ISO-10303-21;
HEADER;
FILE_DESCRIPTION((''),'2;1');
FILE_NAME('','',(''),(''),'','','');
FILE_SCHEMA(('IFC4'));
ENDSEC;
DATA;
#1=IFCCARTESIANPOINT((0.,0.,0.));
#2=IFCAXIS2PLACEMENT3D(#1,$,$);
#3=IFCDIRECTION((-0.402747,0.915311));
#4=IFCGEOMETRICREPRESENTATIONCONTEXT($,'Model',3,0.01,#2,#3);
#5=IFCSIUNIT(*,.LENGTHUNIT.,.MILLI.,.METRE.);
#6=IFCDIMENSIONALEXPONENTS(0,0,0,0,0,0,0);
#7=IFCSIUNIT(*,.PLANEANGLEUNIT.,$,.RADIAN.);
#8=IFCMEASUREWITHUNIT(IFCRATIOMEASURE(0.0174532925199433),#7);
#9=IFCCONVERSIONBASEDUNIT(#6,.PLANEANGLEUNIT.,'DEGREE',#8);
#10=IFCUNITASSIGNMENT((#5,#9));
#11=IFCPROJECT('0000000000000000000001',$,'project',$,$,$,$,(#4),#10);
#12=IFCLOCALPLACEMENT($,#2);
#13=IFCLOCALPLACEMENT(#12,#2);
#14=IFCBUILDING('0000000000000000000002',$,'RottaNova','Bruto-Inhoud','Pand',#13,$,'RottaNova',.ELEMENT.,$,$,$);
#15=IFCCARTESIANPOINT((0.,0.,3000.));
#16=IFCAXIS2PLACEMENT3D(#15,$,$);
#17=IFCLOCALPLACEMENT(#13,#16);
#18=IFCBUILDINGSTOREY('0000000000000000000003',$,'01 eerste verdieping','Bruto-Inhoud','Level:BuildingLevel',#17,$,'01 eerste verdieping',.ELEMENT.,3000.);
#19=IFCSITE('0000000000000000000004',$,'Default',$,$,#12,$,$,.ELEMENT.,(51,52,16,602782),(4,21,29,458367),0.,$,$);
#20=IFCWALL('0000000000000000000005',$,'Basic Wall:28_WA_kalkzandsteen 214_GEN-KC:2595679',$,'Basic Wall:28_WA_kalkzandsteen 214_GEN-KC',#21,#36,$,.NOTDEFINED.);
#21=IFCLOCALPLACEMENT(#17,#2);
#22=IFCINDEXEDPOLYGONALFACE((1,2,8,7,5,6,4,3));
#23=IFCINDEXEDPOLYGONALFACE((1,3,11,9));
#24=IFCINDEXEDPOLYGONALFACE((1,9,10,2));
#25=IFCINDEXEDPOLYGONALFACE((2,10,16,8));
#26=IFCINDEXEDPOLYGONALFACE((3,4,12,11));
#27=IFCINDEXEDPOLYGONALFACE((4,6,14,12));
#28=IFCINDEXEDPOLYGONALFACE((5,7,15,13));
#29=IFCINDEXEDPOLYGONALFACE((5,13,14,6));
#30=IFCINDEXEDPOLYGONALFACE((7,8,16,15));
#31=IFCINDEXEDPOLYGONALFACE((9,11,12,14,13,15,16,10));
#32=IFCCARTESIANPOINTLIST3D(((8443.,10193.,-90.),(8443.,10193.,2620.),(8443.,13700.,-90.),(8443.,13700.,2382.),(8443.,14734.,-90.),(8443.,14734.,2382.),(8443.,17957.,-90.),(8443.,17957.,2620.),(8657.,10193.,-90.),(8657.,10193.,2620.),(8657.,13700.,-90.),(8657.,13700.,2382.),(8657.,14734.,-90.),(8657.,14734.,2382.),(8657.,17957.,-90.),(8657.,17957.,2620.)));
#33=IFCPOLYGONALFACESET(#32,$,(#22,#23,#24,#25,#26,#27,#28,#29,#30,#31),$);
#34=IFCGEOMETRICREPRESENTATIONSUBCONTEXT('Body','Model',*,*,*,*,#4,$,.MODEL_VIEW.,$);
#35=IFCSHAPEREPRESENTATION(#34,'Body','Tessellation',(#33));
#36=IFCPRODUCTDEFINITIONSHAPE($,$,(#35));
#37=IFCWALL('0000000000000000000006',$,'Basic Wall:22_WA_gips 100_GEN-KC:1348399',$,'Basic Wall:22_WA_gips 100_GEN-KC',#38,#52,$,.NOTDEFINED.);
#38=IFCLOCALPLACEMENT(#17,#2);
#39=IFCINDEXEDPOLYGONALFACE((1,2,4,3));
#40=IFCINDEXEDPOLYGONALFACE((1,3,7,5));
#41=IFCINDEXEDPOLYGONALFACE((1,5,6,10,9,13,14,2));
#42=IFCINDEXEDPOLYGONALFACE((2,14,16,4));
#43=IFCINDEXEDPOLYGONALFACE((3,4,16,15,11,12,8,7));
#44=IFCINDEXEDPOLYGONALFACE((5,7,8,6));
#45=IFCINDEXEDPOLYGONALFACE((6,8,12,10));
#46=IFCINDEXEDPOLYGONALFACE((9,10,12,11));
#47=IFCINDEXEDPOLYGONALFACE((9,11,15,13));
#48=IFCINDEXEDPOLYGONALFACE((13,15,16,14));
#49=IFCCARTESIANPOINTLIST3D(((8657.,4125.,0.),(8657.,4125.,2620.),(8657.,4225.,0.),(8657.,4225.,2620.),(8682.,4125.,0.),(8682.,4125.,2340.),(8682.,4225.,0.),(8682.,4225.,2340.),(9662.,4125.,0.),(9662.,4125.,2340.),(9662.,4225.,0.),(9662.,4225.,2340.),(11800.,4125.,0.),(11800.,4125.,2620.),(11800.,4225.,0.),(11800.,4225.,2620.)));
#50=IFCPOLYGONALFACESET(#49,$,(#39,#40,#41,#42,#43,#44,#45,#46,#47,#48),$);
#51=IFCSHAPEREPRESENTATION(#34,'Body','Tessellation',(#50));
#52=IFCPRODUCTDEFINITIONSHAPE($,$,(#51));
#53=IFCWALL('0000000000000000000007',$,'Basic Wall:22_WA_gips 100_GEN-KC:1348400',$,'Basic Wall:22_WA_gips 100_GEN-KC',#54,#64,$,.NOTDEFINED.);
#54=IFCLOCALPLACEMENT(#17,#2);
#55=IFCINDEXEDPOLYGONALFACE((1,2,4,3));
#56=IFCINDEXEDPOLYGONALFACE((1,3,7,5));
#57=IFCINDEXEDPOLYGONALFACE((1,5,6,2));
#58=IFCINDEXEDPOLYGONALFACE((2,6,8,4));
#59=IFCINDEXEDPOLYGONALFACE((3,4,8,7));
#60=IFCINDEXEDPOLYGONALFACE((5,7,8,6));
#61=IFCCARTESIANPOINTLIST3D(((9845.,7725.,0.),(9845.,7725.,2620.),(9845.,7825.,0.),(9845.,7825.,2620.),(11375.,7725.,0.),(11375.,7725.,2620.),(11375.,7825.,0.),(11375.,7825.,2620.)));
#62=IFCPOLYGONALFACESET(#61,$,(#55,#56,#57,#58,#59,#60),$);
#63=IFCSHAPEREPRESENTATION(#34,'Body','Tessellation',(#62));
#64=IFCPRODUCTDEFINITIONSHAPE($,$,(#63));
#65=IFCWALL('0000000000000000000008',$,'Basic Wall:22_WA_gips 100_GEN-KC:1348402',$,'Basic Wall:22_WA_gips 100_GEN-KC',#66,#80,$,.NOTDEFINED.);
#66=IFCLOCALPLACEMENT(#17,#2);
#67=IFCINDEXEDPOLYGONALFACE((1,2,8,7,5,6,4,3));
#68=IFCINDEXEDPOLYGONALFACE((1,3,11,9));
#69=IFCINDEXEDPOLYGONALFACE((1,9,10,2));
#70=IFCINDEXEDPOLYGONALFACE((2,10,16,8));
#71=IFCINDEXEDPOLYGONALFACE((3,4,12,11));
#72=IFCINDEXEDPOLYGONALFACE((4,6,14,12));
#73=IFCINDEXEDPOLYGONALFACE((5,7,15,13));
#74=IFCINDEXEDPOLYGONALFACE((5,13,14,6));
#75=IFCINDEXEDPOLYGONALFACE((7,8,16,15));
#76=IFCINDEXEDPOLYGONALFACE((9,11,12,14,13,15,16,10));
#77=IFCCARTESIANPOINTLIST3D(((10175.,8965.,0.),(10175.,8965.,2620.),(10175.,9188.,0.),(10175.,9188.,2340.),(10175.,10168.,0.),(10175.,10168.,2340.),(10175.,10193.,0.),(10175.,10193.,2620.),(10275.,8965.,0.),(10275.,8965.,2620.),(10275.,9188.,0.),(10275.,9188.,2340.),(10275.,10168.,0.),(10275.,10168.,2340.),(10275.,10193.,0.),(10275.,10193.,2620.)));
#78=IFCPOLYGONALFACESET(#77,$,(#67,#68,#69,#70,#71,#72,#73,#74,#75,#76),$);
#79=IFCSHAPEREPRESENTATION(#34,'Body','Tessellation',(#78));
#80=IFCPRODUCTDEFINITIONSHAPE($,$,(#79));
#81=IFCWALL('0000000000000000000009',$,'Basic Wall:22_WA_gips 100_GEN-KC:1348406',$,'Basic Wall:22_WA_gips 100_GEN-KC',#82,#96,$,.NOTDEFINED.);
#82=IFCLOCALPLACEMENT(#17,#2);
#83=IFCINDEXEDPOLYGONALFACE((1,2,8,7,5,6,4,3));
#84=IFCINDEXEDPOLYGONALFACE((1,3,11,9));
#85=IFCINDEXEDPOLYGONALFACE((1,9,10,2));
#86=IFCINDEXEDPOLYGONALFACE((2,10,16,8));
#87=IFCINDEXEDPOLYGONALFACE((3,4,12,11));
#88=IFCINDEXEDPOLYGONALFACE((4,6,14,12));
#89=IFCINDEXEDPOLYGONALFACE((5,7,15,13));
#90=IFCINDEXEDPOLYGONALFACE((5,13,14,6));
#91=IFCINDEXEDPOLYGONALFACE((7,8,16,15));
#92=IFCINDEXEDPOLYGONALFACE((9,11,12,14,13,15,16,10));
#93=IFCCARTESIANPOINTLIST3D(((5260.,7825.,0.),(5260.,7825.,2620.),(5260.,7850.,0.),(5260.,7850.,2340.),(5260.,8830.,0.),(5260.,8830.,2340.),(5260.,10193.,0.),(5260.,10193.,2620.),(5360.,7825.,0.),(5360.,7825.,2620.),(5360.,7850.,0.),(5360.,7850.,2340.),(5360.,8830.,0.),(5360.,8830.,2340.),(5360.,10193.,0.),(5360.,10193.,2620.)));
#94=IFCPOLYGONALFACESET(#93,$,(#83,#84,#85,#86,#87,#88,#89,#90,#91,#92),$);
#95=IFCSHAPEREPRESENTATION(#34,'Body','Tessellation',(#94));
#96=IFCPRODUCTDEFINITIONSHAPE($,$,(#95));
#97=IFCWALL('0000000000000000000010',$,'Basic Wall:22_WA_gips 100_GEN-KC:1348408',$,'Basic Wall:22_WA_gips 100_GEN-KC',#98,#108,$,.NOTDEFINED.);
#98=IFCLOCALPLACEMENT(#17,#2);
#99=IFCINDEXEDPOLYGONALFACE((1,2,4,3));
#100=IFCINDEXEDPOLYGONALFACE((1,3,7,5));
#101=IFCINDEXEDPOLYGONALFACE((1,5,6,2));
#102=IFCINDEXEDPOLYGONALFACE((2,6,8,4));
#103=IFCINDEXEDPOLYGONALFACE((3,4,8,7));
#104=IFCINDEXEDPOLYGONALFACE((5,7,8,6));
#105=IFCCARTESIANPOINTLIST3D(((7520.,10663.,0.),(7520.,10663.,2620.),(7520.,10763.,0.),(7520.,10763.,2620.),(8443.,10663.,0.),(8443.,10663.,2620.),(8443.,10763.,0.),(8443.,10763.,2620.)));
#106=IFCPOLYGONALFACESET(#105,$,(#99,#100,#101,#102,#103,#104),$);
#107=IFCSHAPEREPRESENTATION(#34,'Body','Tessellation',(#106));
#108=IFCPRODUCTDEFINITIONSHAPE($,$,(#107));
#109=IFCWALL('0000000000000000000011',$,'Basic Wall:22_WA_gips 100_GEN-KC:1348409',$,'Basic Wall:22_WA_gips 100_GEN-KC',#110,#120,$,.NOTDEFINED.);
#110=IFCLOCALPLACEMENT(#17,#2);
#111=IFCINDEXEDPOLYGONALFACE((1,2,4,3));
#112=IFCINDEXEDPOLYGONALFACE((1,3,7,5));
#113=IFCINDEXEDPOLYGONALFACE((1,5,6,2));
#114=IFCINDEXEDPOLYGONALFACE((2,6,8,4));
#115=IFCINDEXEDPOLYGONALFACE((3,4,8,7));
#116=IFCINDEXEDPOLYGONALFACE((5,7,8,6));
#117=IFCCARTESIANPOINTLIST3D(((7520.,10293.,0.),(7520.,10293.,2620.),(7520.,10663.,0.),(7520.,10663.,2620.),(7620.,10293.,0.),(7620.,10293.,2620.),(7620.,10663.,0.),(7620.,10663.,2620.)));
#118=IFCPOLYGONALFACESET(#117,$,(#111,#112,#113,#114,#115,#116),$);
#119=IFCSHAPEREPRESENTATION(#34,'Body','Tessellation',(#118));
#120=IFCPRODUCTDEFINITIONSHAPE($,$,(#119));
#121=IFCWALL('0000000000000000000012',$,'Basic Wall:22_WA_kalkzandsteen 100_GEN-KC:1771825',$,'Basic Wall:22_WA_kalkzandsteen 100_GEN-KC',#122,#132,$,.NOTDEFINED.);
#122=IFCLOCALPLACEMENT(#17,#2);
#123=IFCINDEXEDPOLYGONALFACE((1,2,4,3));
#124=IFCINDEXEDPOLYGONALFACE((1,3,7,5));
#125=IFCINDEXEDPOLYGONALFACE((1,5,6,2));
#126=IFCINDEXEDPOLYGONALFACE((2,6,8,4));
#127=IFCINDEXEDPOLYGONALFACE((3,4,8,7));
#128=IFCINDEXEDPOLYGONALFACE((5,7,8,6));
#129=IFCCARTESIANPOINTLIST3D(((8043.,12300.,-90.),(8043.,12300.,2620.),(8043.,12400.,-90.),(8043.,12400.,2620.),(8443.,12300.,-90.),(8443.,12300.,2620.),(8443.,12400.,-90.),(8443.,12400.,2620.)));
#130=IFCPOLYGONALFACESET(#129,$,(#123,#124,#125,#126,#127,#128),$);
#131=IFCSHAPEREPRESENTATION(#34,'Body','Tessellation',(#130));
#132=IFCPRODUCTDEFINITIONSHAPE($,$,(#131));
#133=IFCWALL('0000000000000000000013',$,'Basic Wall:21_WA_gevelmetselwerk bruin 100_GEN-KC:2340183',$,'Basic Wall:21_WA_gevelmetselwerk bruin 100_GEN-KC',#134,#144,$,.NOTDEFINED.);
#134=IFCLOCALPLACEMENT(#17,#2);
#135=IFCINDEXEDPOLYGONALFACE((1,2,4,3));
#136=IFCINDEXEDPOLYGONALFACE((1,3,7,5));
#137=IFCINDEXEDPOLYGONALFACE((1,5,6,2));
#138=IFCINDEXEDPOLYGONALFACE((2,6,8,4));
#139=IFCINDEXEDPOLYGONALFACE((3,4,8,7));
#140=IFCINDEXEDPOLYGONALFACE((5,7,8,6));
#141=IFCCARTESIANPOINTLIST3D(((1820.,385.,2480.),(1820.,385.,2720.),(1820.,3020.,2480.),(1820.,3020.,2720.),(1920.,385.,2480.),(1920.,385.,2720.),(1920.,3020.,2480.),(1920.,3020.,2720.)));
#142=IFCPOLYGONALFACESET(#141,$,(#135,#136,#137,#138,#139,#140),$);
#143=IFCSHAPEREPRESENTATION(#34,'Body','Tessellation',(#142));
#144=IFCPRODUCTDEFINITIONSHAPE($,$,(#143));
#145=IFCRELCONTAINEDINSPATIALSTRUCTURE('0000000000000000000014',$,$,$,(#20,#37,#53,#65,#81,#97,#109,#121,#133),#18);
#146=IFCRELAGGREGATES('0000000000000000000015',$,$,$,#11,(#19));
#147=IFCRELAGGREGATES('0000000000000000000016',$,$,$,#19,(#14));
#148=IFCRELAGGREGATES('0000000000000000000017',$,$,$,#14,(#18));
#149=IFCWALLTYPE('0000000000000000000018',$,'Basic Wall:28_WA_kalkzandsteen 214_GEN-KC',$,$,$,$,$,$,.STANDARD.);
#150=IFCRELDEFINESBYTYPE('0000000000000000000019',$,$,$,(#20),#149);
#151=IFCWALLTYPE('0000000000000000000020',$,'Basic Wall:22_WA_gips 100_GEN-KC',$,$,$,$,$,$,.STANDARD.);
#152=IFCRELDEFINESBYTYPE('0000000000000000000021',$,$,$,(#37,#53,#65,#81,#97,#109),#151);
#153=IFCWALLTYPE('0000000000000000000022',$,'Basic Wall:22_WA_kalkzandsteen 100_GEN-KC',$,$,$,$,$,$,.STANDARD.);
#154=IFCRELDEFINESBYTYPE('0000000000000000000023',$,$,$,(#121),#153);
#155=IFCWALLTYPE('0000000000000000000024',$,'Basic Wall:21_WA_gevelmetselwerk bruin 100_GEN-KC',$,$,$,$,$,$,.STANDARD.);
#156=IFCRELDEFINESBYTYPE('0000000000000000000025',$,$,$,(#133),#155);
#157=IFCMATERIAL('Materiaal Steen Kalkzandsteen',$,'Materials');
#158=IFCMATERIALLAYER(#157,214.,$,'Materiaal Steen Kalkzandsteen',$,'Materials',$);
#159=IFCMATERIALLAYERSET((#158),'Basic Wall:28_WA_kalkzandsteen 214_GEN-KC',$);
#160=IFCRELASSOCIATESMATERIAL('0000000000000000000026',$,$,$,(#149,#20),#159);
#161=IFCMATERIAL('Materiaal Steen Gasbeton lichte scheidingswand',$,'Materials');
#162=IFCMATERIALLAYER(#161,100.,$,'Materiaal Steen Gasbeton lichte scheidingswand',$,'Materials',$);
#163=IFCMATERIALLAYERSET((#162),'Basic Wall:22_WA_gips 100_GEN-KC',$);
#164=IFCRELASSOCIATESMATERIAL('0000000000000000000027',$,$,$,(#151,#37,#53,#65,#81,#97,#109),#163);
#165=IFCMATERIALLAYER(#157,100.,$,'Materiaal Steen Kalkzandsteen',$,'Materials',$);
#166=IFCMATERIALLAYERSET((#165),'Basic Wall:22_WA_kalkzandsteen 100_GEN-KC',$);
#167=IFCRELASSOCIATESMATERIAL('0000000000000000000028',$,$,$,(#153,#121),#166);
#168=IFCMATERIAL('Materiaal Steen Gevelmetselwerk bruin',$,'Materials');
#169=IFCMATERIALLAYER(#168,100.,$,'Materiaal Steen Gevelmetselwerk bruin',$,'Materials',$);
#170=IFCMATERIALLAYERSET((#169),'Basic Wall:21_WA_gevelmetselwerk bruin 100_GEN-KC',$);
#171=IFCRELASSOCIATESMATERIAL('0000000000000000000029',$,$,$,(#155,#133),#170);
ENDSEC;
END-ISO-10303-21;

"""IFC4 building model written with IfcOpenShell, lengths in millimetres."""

from ifc_helpers import new_model, entity, si_unit, converted_unit, direction, frame, frame_2d, origin, place, context, subcontext, project, spatial, rectangle, extrude, material, layer, layer_set, type_object, element, save


model = new_model("IFC4")

# Units and contexts
model_context = context("Model", 3, precision=0.01, world=origin(), true_north=direction((-0.402747, 0.915311)))
body_context = subcontext(model_context, "Body", "Model", "MODEL_VIEW")
ifc_project = project(units=[si_unit("LENGTHUNIT", "METRE", prefix="MILLI"), converted_unit("PLANEANGLEUNIT", "DEGREE", entity("IfcRatioMeasure", 0.0174532925199433), si_unit("PLANEANGLEUNIT", "RADIAN"), dimensions=[0, 0, 0, 0, 0, 0, 0])], contexts=[model_context])

# Site, building, storey
site_placement = place(None, origin())
site = spatial("IfcSite", under=ifc_project, at=site_placement, Name="Default", CompositionType="ELEMENT", RefLatitude=(51, 52, 16, 602782), RefLongitude=(4, 21, 29, 458367), RefElevation=0.0)
building_placement = place(site_placement, origin())
building = spatial("IfcBuilding", under=site, at=building_placement, Name="RottaNova", Description="Bruto-Inhoud", ObjectType="Pand", LongName="RottaNova", CompositionType="ELEMENT")
storey_placement = place(building_placement, frame((0.0, 0.0, 3000.0)))
storey = spatial("IfcBuildingStorey", under=building, at=storey_placement, Name="01 eerste verdieping", Description="Bruto-Inhoud", ObjectType="Level:BuildingLevel", LongName="01 eerste verdieping", CompositionType="ELEMENT", Elevation=3000.0)

# Shared definitions
ifc_material_1 = material(Name="Materiaal Steen Kalkzandsteen", Category="Materials")
ifc_layer_1 = layer(ifc_material_1, 214.0, Name="Materiaal Steen Kalkzandsteen", Category="Materials")
ifc_layer_set_1 = layer_set([ifc_layer_1], Name="Basic Wall:28_WA_kalkzandsteen 214_GEN-KC")
wall_type_1 = type_object("IfcWallType", Name="Basic Wall:28_WA_kalkzandsteen 214_GEN-KC", PredefinedType="STANDARD", material=ifc_layer_set_1)

# Walls, openings
wall_1_placement = place(storey_placement, frame((8550.0, 10193.0, -90.0), z_axis=(0.0, 0.0, 1.0), x_axis=(0.0, 1.0, 0.0)))
wall_1 = element("IfcWall", 1, at=wall_1_placement, inside=storey, type_object=wall_type_1, material=ifc_layer_set_1, Name="Basic Wall:28_WA_kalkzandsteen 214_GEN-KC:2595679", ObjectType="Basic Wall:28_WA_kalkzandsteen 214_GEN-KC", PredefinedType="NOTDEFINED", context=body_context, shape_type="SweptSolid", body=[
    extrude(rectangle(XDim=7764.0, YDim=214.0, at=frame_2d((3882.0, 0.0), x_axis=(1.0, 0.0))), origin(), (0.0, 0.0, 1.0), 2710.0),
])
opening_1_placement = place(wall_1_placement, frame((3507.0, 107.0, 0.0)))
element("IfcOpeningElement", 2, at=opening_1_placement, cuts=wall_1, PredefinedType="OPENING", context=body_context, shape_type="SweptSolid", body=[
    extrude(rectangle(XDim=2472.0, YDim=1034.0, at=frame_2d((0.0, 0.0), x_axis=(1.0, 0.0))), frame((517.0, -214.0, 1236.0), z_axis=(0.0, 1.0, 0.0), x_axis=(0.0, 0.0, -1.0)), (0.0, 0.0, 1.0), 214.0),
])
ifc_material_2 = material(Name="Materiaal Steen Gasbeton lichte scheidingswand", Category="Materials")
ifc_layer_2 = layer(ifc_material_2, 100.0, Name="Materiaal Steen Gasbeton lichte scheidingswand", Category="Materials")
ifc_layer_set_2 = layer_set([ifc_layer_2], Name="Basic Wall:22_WA_gips 100_GEN-KC")
wall_type_2 = type_object("IfcWallType", Name="Basic Wall:22_WA_gips 100_GEN-KC", PredefinedType="STANDARD", material=ifc_layer_set_2)
wall_2_placement = place(storey_placement, frame((8657.0, 4175.0, 0.0)))
wall_2 = element("IfcWall", 3, at=wall_2_placement, inside=storey, type_object=wall_type_2, material=ifc_layer_set_2, Name="Basic Wall:22_WA_gips 100_GEN-KC:1348399", ObjectType="Basic Wall:22_WA_gips 100_GEN-KC", PredefinedType="NOTDEFINED", context=body_context, shape_type="SweptSolid", body=[
    extrude(rectangle(XDim=3143.0, YDim=100.0, at=frame_2d((1571.5, 0.0), x_axis=(-1.0, 0.0))), origin(), (0.0, 0.0, 1.0), 2620.0),
])
opening_2_placement = place(wall_2_placement, frame((1005.0, 50.0, -90.0)))
element("IfcOpeningElement", 4, at=opening_2_placement, cuts=wall_2, PredefinedType="OPENING", context=body_context, shape_type="SweptSolid", body=[
    extrude(rectangle(XDim=2430.0, YDim=980.0, at=frame_2d((1215.0, 490.0), x_axis=(1.0, 0.0))), frame((0.0, 0.0, 0.0), z_axis=(0.0, -1.0, 0.0), x_axis=(0.0, 0.0, 1.0)), (0.0, 0.0, 1.0), 100.0),
])

# Wall
wall_3_placement = place(storey_placement, frame((9845.0, 7775.0, 0.0)))
element("IfcWall", 5, at=wall_3_placement, inside=storey, type_object=wall_type_2, material=ifc_layer_set_2, Name="Basic Wall:22_WA_gips 100_GEN-KC:1348400", ObjectType="Basic Wall:22_WA_gips 100_GEN-KC", PredefinedType="NOTDEFINED", context=body_context, shape_type="SweptSolid", body=[
    extrude(rectangle(XDim=1530.0, YDim=100.0, at=frame_2d((765.0, 0.0), x_axis=(-1.0, 0.0))), origin(), (0.0, 0.0, 1.0), 2620.0),
])

# Walls, openings
wall_4_placement = place(storey_placement, frame((10225.0, 8965.0, 0.0), z_axis=(0.0, 0.0, 1.0), x_axis=(0.0, 1.0, 0.0)))
wall_4 = element("IfcWall", 6, at=wall_4_placement, inside=storey, type_object=wall_type_2, material=ifc_layer_set_2, Name="Basic Wall:22_WA_gips 100_GEN-KC:1348402", ObjectType="Basic Wall:22_WA_gips 100_GEN-KC", PredefinedType="NOTDEFINED", context=body_context, shape_type="SweptSolid", body=[
    extrude(rectangle(XDim=1228.0, YDim=100.0, at=frame_2d((614.0, 0.0), x_axis=(1.0, 0.0))), origin(), (0.0, 0.0, 1.0), 2620.0),
])
opening_3_placement = place(wall_4_placement, frame((223.0, -50.0, -90.0)))
element("IfcOpeningElement", 7, at=opening_3_placement, cuts=wall_4, PredefinedType="OPENING", context=body_context, shape_type="SweptSolid", body=[
    extrude(rectangle(XDim=2430.0, YDim=980.0, at=frame_2d((1215.0, 490.0), x_axis=(1.0, 0.0))), frame((0.0, 0.0, 0.0), z_axis=(0.0, 1.0, 0.0), x_axis=(0.0, 0.0, 1.0)), (0.0, 0.0, 1.0), 100.0),
])
wall_5_placement = place(storey_placement, frame((5310.0, 10193.0, 0.0), z_axis=(0.0, 0.0, 1.0), x_axis=(0.0, -1.0, 0.0)))
wall_5 = element("IfcWall", 8, at=wall_5_placement, inside=storey, type_object=wall_type_2, material=ifc_layer_set_2, Name="Basic Wall:22_WA_gips 100_GEN-KC:1348406", ObjectType="Basic Wall:22_WA_gips 100_GEN-KC", PredefinedType="NOTDEFINED", context=body_context, shape_type="SweptSolid", body=[
    extrude(rectangle(XDim=2368.0, YDim=100.0, at=frame_2d((1184.0, 0.0), x_axis=(1.0, 0.0))), origin(), (0.0, 0.0, 1.0), 2620.0),
])
opening_4_placement = place(wall_5_placement, frame((2343.0, 50.0, -90.0)))
element("IfcOpeningElement", 9, at=opening_4_placement, cuts=wall_5, PredefinedType="OPENING", context=body_context, shape_type="SweptSolid", body=[
    extrude(rectangle(XDim=2430.0, YDim=980.0, at=frame_2d((1215.0, 490.0), x_axis=(1.0, 0.0))), frame((0.0, 0.0, 0.0), z_axis=(0.0, -1.0, 0.0), x_axis=(0.0, 0.0, 1.0)), (0.0, 0.0, 1.0), 100.0),
])

# Walls
wall_6_placement = place(storey_placement, frame((7520.0, 10713.0, 0.0)))
element("IfcWall", 10, at=wall_6_placement, inside=storey, type_object=wall_type_2, material=ifc_layer_set_2, Name="Basic Wall:22_WA_gips 100_GEN-KC:1348408", ObjectType="Basic Wall:22_WA_gips 100_GEN-KC", PredefinedType="NOTDEFINED", context=body_context, shape_type="SweptSolid", body=[
    extrude(rectangle(XDim=923.0, YDim=100.0, at=frame_2d((461.5, 0.0), x_axis=(-1.0, 0.0))), origin(), (0.0, 0.0, 1.0), 2620.0),
])
wall_7_placement = place(storey_placement, frame((7570.0, 10663.0, 0.0), z_axis=(0.0, 0.0, 1.0), x_axis=(0.0, -1.0, 0.0)))
element("IfcWall", 11, at=wall_7_placement, inside=storey, type_object=wall_type_2, material=ifc_layer_set_2, Name="Basic Wall:22_WA_gips 100_GEN-KC:1348409", ObjectType="Basic Wall:22_WA_gips 100_GEN-KC", PredefinedType="NOTDEFINED", context=body_context, shape_type="SweptSolid", body=[
    extrude(rectangle(XDim=370.0, YDim=100.0, at=frame_2d((185.0, 0.0), x_axis=(-1.0, 0.0))), origin(), (0.0, 0.0, 1.0), 2620.0),
])
ifc_layer_3 = layer(ifc_material_1, 100.0, Name="Materiaal Steen Kalkzandsteen", Category="Materials")
ifc_layer_set_3 = layer_set([ifc_layer_3], Name="Basic Wall:22_WA_kalkzandsteen 100_GEN-KC")
wall_type_3 = type_object("IfcWallType", Name="Basic Wall:22_WA_kalkzandsteen 100_GEN-KC", PredefinedType="STANDARD", material=ifc_layer_set_3)
wall_8_placement = place(storey_placement, frame((8043.0, 12350.0, -90.0)))
element("IfcWall", 12, at=wall_8_placement, inside=storey, type_object=wall_type_3, material=ifc_layer_set_3, Name="Basic Wall:22_WA_kalkzandsteen 100_GEN-KC:1771825", ObjectType="Basic Wall:22_WA_kalkzandsteen 100_GEN-KC", PredefinedType="NOTDEFINED", context=body_context, shape_type="SweptSolid", body=[
    extrude(rectangle(XDim=400.0, YDim=100.0, at=frame_2d((200.0, 0.0), x_axis=(-1.0, 0.0))), origin(), (0.0, 0.0, 1.0), 2710.0),
])
ifc_material_3 = material(Name="Materiaal Steen Gevelmetselwerk bruin", Category="Materials")
ifc_layer_4 = layer(ifc_material_3, 100.0, Name="Materiaal Steen Gevelmetselwerk bruin", Category="Materials")
ifc_layer_set_4 = layer_set([ifc_layer_4], Name="Basic Wall:21_WA_gevelmetselwerk bruin 100_GEN-KC")
wall_type_4 = type_object("IfcWallType", Name="Basic Wall:21_WA_gevelmetselwerk bruin 100_GEN-KC", PredefinedType="STANDARD", material=ifc_layer_set_4)
wall_9_placement = place(storey_placement, frame((1870.0, 3020.0, 2480.0), z_axis=(0.0, 0.0, 1.0), x_axis=(0.0, -1.0, 0.0)))
element("IfcWall", 13, at=wall_9_placement, inside=storey, type_object=wall_type_4, material=ifc_layer_set_4, Name="Basic Wall:21_WA_gevelmetselwerk bruin 100_GEN-KC:2340183", ObjectType="Basic Wall:21_WA_gevelmetselwerk bruin 100_GEN-KC", PredefinedType="NOTDEFINED", context=body_context, shape_type="SweptSolid", body=[
    extrude(rectangle(XDim=2635.0, YDim=100.0, at=frame_2d((1317.5, 0.0), x_axis=(-1.0, 0.0))), origin(), (0.0, 0.0, 1.0), 240.0),
])

save(model, "model.ifc")
